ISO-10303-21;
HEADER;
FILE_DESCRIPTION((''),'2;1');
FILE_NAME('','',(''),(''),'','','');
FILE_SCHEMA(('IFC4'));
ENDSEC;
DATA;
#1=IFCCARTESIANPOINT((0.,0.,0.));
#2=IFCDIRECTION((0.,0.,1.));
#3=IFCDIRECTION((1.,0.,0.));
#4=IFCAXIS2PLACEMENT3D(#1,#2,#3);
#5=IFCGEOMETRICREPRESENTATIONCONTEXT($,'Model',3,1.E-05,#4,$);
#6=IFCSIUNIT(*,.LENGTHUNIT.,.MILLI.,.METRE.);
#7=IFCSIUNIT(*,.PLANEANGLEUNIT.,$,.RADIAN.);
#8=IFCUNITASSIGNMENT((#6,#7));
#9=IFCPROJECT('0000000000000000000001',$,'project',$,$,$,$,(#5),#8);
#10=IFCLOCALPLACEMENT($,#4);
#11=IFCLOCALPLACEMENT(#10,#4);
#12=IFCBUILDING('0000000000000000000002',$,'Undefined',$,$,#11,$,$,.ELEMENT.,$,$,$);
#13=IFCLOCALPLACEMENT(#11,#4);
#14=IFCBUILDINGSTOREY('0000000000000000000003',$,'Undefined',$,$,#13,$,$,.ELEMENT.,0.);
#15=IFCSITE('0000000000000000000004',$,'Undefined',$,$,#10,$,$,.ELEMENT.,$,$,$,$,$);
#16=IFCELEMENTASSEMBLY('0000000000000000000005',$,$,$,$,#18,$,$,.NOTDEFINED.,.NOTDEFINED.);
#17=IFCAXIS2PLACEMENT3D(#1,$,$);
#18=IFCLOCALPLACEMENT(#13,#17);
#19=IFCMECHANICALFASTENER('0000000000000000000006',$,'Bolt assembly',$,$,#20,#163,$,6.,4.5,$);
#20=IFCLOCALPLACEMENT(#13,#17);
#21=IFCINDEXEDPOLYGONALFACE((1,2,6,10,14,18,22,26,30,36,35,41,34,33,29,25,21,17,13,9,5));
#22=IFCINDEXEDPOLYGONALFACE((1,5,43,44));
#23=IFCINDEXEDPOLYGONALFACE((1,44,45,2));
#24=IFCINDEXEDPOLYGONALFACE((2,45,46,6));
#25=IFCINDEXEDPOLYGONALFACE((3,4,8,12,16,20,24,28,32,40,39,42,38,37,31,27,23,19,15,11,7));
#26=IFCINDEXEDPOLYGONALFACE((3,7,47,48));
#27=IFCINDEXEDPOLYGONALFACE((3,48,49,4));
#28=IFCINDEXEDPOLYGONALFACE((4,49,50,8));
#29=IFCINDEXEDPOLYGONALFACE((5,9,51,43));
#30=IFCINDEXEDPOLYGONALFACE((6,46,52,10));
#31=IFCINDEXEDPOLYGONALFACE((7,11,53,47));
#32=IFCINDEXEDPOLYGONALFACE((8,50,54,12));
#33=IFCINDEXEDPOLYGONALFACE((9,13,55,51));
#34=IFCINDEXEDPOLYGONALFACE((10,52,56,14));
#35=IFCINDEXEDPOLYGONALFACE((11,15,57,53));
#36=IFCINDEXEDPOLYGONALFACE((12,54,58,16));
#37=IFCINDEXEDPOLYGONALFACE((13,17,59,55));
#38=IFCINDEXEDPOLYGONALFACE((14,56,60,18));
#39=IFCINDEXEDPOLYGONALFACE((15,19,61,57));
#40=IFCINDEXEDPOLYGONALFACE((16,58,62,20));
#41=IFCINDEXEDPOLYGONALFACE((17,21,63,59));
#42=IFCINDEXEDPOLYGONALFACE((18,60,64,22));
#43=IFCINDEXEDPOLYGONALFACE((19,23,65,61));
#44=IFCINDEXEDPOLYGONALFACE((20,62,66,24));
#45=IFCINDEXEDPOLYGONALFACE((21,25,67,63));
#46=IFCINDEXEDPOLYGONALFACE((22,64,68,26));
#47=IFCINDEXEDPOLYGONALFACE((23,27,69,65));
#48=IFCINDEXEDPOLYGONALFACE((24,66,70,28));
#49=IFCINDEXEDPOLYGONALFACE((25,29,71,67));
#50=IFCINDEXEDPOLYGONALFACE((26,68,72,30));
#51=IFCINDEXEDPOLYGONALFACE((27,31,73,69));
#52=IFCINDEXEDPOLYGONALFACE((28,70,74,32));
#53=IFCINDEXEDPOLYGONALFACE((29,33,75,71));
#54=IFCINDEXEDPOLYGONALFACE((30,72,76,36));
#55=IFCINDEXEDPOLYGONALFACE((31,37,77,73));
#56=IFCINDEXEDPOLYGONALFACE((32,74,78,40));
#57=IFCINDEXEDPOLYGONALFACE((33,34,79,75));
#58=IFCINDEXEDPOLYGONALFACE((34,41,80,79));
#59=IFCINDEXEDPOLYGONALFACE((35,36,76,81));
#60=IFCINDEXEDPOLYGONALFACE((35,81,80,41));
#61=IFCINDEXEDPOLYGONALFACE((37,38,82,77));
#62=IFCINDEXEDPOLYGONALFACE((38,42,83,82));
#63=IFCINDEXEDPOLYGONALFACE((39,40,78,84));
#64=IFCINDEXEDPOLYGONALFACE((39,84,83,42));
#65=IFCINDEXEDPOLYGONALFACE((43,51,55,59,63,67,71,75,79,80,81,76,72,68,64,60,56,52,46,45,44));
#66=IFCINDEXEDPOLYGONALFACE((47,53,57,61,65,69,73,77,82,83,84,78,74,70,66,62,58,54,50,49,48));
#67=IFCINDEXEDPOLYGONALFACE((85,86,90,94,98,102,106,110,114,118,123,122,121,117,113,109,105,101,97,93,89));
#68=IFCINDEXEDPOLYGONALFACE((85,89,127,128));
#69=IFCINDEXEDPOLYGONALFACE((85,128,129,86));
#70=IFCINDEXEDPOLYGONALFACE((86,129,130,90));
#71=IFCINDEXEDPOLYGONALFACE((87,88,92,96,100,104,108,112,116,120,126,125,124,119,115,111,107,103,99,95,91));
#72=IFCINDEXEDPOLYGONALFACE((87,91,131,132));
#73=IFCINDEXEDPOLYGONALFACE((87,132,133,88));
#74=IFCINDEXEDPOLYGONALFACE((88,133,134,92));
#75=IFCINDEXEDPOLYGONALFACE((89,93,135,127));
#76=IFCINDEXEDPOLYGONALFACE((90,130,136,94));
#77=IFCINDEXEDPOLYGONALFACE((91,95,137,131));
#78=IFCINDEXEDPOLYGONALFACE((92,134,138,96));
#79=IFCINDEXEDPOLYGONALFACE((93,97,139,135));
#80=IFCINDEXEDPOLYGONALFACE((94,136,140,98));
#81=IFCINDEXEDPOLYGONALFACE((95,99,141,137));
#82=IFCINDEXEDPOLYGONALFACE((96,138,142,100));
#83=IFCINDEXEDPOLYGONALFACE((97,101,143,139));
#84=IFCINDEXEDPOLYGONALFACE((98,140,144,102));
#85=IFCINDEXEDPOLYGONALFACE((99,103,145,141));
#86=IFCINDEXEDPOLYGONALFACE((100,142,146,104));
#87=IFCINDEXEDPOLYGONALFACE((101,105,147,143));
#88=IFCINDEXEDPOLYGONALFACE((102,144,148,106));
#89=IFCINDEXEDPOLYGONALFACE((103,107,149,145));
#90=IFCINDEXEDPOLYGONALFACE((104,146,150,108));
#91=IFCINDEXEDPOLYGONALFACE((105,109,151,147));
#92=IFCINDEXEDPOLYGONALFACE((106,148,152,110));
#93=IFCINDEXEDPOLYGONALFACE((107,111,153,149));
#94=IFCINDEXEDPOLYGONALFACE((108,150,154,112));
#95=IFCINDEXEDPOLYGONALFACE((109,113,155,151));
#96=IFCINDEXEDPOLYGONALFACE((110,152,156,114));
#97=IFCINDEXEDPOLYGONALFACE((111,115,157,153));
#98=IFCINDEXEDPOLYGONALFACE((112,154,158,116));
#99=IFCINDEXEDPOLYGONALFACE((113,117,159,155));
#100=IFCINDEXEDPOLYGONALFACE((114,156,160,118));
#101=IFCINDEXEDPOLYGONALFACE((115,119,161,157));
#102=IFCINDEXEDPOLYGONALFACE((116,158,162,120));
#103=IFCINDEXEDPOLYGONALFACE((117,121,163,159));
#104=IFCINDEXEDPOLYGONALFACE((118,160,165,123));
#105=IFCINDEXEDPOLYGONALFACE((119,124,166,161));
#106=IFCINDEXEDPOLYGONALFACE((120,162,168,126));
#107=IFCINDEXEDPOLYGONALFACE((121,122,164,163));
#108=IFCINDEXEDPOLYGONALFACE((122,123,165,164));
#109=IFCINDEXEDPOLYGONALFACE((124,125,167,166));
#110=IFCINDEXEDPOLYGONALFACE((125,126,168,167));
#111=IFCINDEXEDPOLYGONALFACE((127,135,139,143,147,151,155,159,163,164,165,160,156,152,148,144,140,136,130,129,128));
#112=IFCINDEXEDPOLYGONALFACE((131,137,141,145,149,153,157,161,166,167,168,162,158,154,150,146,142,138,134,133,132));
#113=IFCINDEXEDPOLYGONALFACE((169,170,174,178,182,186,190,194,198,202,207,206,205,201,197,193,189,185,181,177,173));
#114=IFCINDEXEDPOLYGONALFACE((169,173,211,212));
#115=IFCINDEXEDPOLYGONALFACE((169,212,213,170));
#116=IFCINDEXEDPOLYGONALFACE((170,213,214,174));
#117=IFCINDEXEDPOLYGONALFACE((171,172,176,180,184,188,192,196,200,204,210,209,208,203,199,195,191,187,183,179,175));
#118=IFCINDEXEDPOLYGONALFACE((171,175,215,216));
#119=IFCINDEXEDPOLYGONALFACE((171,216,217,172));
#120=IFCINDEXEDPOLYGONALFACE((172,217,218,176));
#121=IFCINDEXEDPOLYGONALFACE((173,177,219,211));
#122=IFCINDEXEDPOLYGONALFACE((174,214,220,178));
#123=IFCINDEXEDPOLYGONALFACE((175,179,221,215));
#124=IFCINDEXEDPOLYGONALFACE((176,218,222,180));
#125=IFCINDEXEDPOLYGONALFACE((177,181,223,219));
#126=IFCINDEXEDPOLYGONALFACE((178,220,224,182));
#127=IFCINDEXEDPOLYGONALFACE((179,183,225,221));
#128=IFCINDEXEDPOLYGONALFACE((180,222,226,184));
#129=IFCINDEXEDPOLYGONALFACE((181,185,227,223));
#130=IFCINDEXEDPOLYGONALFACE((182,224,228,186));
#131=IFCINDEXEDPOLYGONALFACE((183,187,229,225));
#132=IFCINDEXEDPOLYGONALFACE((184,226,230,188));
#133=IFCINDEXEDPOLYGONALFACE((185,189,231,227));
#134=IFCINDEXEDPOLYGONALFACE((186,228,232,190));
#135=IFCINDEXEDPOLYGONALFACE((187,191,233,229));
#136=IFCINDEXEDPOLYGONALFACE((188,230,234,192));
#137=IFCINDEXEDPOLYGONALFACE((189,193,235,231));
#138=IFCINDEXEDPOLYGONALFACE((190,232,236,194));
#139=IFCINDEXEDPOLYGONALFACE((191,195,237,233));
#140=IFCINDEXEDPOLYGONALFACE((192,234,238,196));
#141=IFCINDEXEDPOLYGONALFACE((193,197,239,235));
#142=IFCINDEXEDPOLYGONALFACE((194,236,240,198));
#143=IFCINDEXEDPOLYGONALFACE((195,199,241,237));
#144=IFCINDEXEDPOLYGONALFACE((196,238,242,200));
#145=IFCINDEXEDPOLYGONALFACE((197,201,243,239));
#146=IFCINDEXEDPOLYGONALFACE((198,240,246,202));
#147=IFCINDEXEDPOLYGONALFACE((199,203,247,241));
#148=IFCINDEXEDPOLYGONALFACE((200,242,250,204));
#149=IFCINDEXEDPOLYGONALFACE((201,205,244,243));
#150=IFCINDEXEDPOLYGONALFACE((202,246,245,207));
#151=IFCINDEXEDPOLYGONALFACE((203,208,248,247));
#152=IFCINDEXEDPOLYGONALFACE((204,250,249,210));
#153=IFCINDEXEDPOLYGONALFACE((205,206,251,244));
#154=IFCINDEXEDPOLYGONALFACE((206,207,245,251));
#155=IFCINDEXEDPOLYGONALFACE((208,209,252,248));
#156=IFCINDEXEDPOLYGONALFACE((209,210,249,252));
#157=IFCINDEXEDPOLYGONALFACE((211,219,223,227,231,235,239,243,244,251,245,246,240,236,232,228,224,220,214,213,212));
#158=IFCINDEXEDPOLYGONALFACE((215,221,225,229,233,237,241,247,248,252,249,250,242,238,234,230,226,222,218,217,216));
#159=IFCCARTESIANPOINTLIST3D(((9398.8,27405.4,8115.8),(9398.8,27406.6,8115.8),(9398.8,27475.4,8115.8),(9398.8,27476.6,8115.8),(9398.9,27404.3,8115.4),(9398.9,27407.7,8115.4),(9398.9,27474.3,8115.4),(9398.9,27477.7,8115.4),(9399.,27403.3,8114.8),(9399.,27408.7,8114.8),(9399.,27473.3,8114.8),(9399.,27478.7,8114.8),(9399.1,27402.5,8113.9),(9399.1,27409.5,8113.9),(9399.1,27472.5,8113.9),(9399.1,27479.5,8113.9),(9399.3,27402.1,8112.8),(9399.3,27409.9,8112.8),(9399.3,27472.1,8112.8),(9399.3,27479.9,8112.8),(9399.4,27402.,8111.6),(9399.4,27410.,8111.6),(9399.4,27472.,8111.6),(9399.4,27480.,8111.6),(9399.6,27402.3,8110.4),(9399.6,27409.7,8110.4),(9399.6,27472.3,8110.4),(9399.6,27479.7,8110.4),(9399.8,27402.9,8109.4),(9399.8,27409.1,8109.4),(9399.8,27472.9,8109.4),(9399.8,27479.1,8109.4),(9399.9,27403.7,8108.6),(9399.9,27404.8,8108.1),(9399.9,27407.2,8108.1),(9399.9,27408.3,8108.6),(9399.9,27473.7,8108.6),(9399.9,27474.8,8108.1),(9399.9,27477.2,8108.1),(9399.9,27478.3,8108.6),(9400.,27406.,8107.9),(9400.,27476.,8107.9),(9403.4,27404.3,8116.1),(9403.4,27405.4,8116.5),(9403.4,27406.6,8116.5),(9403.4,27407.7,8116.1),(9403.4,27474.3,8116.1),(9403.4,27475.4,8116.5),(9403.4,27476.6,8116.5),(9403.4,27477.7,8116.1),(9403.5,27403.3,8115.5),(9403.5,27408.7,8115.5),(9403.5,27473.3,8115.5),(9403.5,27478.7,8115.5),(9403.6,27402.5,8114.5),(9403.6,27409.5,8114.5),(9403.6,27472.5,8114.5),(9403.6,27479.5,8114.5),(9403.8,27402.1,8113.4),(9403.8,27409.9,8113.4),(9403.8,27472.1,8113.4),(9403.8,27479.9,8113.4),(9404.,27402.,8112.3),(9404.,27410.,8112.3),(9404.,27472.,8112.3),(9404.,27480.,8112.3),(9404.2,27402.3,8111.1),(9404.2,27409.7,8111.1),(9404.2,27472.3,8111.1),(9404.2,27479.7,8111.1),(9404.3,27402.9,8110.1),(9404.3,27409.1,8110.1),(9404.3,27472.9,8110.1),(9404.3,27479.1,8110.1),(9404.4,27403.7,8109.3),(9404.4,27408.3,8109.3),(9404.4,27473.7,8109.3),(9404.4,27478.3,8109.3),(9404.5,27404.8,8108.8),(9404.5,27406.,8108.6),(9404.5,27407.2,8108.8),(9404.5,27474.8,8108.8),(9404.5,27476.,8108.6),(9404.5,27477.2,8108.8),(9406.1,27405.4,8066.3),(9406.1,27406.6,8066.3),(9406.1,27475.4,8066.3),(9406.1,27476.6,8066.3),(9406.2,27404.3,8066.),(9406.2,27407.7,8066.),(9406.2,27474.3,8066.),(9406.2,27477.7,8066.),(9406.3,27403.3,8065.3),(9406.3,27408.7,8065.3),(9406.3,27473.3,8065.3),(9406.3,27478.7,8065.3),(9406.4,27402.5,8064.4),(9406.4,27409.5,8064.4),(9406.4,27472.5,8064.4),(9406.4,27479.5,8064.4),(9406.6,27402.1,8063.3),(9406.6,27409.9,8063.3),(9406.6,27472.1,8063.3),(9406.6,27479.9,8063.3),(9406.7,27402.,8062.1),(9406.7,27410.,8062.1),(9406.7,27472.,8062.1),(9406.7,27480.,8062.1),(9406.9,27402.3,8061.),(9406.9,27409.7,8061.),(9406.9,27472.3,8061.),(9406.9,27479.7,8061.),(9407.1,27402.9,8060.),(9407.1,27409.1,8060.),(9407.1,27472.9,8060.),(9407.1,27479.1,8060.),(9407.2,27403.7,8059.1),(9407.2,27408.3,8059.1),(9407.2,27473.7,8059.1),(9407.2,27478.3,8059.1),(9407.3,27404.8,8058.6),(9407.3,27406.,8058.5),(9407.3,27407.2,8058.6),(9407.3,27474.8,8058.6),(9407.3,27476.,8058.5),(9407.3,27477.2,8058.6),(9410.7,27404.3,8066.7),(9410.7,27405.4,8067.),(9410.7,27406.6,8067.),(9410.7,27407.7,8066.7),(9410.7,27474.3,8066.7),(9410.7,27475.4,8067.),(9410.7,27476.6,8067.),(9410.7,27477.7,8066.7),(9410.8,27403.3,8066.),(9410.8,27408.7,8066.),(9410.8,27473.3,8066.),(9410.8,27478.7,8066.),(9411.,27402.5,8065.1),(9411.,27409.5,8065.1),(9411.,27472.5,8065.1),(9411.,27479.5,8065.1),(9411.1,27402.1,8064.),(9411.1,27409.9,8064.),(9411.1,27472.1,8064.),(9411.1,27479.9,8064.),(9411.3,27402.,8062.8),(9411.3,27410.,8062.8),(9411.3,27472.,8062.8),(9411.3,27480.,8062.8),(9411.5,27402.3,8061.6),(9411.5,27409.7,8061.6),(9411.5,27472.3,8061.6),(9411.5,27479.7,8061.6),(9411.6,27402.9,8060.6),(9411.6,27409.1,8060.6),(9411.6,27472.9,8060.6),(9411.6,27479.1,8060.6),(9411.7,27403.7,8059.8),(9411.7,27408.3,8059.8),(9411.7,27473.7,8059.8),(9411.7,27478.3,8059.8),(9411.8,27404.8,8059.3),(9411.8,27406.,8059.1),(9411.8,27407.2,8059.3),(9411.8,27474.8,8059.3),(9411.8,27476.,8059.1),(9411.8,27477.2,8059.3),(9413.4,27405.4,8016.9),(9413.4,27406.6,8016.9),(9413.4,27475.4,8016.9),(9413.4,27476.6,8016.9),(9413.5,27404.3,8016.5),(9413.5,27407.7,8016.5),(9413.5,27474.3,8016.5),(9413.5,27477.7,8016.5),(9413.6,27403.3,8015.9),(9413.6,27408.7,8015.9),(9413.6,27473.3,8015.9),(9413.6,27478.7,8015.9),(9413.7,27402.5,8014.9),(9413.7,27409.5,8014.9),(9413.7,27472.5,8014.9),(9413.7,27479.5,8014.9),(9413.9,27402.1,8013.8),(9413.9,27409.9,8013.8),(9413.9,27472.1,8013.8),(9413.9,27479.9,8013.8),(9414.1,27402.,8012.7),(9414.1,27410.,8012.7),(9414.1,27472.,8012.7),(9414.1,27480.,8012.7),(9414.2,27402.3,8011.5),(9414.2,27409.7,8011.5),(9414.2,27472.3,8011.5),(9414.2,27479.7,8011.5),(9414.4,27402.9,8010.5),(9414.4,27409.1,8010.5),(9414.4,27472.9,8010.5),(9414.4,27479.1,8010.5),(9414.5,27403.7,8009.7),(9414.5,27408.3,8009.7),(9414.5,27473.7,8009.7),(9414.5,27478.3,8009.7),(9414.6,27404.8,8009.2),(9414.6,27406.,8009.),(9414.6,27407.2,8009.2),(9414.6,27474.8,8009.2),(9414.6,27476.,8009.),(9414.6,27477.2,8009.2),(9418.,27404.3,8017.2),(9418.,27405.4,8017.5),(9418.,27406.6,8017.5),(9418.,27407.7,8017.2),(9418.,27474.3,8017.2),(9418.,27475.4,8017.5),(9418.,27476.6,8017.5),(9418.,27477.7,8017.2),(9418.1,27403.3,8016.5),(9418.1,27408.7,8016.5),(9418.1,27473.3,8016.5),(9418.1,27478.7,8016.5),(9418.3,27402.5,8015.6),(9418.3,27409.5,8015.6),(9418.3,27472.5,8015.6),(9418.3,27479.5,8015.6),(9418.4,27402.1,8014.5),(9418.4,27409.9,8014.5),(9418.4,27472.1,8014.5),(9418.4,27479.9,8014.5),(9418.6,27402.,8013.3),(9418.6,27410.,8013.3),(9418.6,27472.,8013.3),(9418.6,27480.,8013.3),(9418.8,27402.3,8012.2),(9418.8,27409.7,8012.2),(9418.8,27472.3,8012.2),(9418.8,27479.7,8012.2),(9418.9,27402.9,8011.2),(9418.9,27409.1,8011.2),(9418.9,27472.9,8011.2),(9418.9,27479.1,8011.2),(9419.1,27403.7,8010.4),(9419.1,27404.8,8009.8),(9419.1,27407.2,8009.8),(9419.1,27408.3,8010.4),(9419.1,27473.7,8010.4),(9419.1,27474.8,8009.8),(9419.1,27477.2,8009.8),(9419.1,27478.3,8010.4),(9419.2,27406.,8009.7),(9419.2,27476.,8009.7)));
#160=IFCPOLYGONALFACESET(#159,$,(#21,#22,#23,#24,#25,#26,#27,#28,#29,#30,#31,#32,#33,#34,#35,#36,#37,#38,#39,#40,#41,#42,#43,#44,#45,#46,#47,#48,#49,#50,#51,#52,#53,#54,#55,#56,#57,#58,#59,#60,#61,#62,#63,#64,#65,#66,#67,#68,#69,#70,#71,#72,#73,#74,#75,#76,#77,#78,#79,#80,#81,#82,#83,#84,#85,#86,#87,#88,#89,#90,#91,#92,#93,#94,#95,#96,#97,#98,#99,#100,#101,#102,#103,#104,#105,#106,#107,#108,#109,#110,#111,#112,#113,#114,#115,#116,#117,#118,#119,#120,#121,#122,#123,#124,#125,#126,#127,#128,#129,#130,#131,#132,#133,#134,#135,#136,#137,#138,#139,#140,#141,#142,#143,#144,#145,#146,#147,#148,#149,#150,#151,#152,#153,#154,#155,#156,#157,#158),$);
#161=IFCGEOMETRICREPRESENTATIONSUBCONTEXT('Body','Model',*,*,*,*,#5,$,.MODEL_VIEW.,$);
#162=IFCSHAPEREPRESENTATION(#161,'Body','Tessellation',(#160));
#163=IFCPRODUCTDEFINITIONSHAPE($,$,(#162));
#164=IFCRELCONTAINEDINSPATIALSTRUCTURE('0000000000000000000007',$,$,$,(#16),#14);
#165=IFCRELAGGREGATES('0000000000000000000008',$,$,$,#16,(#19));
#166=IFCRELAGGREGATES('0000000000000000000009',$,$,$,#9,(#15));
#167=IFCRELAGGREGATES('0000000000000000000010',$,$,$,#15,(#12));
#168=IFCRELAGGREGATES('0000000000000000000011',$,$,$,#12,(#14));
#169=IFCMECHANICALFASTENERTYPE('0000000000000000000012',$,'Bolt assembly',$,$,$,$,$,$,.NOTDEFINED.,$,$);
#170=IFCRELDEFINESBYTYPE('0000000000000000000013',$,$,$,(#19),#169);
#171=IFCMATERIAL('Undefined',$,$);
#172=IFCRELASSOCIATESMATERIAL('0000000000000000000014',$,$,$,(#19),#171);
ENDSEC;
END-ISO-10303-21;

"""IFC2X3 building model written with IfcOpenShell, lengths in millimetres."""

from ifc_helpers import new_model, si_unit, frame, origin_with_axes, origin_2d_with_axis, place, context, subcontext, project, spatial, circle, extrude, source, transform, mapped, material, type_object, element, aggregate, save


model = new_model("IFC2X3")

# Units and contexts
model_context = context("Model", 3, precision=1e-05, world=origin_with_axes())
body_context = subcontext(model_context, "Body", "Model", "MODEL_VIEW")
ifc_project = project(units=[si_unit("LENGTHUNIT", "METRE", prefix="MILLI"), si_unit("PLANEANGLEUNIT", "RADIAN")], contexts=[model_context])

# Site, building, storey
site_placement = place(None, origin_with_axes())
site = spatial("IfcSite", under=ifc_project, at=site_placement, Name="Undefined", CompositionType="ELEMENT")
building_placement = place(site_placement, origin_with_axes())
building = spatial("IfcBuilding", under=site, at=building_placement, Name="Undefined", CompositionType="ELEMENT")
storey_placement = place(building_placement, origin_with_axes())
storey = spatial("IfcBuildingStorey", under=building, at=storey_placement, Name="Undefined", CompositionType="ELEMENT", Elevation=0.0)

# Element assembly
assembly_1_placement = place(storey_placement, origin_with_axes())
assembly_1 = element("IfcElementAssembly", 1, at=assembly_1_placement, inside=storey, AssemblyPlace="NOTDEFINED", PredefinedType="NOTDEFINED")

# Mechanical fastener
ifc_material_1 = material(Name="Undefined")
mechanical_fastener_type = type_object("IfcMechanicalFastenerType", Name="Bolt assembly")
shared_shape_1 = source(origin_with_axes(), body_context, "Body", "SweptSolid", [
    extrude(circle(Radius=4.0, at=origin_2d_with_axis()), frame((0.0, 0.0, 0.0), z_axis=(0.0, 1.0, 0.0), x_axis=(1.0, 0.0, 0.0)), (0.0, 0.0, 1.0), 4.6),
])
mechanical_fastener_1_placement = place(assembly_1_placement, frame((9403.9, 27441.0, 8112.6), z_axis=(0.0, 1.0, 0.0), x_axis=(0.14631, 0.0, -0.989239)))
mechanical_fastener_1 = element("IfcMechanicalFastener", 2, at=mechanical_fastener_1_placement, type_object=mechanical_fastener_type, material=ifc_material_1, Name="Bolt assembly", NominalDiameter=6.0, NominalLength=4.5, context=body_context, shape_type="MappedRepresentation", body=[
    mapped(shared_shape_1, transform((0.0, 0.0, 35.0))),
    mapped(shared_shape_1, transform((50.0, 0.0, 35.0))),
    mapped(shared_shape_1, transform((100.0, 0.0, 35.0))),
    mapped(shared_shape_1, transform((0.0, 0.0, -35.0))),
    mapped(shared_shape_1, transform((50.0, 0.0, -35.0))),
    mapped(shared_shape_1, transform((100.0, 0.0, -35.0))),
])

aggregate(assembly_1, [mechanical_fastener_1])

save(model, "model.ifc")
